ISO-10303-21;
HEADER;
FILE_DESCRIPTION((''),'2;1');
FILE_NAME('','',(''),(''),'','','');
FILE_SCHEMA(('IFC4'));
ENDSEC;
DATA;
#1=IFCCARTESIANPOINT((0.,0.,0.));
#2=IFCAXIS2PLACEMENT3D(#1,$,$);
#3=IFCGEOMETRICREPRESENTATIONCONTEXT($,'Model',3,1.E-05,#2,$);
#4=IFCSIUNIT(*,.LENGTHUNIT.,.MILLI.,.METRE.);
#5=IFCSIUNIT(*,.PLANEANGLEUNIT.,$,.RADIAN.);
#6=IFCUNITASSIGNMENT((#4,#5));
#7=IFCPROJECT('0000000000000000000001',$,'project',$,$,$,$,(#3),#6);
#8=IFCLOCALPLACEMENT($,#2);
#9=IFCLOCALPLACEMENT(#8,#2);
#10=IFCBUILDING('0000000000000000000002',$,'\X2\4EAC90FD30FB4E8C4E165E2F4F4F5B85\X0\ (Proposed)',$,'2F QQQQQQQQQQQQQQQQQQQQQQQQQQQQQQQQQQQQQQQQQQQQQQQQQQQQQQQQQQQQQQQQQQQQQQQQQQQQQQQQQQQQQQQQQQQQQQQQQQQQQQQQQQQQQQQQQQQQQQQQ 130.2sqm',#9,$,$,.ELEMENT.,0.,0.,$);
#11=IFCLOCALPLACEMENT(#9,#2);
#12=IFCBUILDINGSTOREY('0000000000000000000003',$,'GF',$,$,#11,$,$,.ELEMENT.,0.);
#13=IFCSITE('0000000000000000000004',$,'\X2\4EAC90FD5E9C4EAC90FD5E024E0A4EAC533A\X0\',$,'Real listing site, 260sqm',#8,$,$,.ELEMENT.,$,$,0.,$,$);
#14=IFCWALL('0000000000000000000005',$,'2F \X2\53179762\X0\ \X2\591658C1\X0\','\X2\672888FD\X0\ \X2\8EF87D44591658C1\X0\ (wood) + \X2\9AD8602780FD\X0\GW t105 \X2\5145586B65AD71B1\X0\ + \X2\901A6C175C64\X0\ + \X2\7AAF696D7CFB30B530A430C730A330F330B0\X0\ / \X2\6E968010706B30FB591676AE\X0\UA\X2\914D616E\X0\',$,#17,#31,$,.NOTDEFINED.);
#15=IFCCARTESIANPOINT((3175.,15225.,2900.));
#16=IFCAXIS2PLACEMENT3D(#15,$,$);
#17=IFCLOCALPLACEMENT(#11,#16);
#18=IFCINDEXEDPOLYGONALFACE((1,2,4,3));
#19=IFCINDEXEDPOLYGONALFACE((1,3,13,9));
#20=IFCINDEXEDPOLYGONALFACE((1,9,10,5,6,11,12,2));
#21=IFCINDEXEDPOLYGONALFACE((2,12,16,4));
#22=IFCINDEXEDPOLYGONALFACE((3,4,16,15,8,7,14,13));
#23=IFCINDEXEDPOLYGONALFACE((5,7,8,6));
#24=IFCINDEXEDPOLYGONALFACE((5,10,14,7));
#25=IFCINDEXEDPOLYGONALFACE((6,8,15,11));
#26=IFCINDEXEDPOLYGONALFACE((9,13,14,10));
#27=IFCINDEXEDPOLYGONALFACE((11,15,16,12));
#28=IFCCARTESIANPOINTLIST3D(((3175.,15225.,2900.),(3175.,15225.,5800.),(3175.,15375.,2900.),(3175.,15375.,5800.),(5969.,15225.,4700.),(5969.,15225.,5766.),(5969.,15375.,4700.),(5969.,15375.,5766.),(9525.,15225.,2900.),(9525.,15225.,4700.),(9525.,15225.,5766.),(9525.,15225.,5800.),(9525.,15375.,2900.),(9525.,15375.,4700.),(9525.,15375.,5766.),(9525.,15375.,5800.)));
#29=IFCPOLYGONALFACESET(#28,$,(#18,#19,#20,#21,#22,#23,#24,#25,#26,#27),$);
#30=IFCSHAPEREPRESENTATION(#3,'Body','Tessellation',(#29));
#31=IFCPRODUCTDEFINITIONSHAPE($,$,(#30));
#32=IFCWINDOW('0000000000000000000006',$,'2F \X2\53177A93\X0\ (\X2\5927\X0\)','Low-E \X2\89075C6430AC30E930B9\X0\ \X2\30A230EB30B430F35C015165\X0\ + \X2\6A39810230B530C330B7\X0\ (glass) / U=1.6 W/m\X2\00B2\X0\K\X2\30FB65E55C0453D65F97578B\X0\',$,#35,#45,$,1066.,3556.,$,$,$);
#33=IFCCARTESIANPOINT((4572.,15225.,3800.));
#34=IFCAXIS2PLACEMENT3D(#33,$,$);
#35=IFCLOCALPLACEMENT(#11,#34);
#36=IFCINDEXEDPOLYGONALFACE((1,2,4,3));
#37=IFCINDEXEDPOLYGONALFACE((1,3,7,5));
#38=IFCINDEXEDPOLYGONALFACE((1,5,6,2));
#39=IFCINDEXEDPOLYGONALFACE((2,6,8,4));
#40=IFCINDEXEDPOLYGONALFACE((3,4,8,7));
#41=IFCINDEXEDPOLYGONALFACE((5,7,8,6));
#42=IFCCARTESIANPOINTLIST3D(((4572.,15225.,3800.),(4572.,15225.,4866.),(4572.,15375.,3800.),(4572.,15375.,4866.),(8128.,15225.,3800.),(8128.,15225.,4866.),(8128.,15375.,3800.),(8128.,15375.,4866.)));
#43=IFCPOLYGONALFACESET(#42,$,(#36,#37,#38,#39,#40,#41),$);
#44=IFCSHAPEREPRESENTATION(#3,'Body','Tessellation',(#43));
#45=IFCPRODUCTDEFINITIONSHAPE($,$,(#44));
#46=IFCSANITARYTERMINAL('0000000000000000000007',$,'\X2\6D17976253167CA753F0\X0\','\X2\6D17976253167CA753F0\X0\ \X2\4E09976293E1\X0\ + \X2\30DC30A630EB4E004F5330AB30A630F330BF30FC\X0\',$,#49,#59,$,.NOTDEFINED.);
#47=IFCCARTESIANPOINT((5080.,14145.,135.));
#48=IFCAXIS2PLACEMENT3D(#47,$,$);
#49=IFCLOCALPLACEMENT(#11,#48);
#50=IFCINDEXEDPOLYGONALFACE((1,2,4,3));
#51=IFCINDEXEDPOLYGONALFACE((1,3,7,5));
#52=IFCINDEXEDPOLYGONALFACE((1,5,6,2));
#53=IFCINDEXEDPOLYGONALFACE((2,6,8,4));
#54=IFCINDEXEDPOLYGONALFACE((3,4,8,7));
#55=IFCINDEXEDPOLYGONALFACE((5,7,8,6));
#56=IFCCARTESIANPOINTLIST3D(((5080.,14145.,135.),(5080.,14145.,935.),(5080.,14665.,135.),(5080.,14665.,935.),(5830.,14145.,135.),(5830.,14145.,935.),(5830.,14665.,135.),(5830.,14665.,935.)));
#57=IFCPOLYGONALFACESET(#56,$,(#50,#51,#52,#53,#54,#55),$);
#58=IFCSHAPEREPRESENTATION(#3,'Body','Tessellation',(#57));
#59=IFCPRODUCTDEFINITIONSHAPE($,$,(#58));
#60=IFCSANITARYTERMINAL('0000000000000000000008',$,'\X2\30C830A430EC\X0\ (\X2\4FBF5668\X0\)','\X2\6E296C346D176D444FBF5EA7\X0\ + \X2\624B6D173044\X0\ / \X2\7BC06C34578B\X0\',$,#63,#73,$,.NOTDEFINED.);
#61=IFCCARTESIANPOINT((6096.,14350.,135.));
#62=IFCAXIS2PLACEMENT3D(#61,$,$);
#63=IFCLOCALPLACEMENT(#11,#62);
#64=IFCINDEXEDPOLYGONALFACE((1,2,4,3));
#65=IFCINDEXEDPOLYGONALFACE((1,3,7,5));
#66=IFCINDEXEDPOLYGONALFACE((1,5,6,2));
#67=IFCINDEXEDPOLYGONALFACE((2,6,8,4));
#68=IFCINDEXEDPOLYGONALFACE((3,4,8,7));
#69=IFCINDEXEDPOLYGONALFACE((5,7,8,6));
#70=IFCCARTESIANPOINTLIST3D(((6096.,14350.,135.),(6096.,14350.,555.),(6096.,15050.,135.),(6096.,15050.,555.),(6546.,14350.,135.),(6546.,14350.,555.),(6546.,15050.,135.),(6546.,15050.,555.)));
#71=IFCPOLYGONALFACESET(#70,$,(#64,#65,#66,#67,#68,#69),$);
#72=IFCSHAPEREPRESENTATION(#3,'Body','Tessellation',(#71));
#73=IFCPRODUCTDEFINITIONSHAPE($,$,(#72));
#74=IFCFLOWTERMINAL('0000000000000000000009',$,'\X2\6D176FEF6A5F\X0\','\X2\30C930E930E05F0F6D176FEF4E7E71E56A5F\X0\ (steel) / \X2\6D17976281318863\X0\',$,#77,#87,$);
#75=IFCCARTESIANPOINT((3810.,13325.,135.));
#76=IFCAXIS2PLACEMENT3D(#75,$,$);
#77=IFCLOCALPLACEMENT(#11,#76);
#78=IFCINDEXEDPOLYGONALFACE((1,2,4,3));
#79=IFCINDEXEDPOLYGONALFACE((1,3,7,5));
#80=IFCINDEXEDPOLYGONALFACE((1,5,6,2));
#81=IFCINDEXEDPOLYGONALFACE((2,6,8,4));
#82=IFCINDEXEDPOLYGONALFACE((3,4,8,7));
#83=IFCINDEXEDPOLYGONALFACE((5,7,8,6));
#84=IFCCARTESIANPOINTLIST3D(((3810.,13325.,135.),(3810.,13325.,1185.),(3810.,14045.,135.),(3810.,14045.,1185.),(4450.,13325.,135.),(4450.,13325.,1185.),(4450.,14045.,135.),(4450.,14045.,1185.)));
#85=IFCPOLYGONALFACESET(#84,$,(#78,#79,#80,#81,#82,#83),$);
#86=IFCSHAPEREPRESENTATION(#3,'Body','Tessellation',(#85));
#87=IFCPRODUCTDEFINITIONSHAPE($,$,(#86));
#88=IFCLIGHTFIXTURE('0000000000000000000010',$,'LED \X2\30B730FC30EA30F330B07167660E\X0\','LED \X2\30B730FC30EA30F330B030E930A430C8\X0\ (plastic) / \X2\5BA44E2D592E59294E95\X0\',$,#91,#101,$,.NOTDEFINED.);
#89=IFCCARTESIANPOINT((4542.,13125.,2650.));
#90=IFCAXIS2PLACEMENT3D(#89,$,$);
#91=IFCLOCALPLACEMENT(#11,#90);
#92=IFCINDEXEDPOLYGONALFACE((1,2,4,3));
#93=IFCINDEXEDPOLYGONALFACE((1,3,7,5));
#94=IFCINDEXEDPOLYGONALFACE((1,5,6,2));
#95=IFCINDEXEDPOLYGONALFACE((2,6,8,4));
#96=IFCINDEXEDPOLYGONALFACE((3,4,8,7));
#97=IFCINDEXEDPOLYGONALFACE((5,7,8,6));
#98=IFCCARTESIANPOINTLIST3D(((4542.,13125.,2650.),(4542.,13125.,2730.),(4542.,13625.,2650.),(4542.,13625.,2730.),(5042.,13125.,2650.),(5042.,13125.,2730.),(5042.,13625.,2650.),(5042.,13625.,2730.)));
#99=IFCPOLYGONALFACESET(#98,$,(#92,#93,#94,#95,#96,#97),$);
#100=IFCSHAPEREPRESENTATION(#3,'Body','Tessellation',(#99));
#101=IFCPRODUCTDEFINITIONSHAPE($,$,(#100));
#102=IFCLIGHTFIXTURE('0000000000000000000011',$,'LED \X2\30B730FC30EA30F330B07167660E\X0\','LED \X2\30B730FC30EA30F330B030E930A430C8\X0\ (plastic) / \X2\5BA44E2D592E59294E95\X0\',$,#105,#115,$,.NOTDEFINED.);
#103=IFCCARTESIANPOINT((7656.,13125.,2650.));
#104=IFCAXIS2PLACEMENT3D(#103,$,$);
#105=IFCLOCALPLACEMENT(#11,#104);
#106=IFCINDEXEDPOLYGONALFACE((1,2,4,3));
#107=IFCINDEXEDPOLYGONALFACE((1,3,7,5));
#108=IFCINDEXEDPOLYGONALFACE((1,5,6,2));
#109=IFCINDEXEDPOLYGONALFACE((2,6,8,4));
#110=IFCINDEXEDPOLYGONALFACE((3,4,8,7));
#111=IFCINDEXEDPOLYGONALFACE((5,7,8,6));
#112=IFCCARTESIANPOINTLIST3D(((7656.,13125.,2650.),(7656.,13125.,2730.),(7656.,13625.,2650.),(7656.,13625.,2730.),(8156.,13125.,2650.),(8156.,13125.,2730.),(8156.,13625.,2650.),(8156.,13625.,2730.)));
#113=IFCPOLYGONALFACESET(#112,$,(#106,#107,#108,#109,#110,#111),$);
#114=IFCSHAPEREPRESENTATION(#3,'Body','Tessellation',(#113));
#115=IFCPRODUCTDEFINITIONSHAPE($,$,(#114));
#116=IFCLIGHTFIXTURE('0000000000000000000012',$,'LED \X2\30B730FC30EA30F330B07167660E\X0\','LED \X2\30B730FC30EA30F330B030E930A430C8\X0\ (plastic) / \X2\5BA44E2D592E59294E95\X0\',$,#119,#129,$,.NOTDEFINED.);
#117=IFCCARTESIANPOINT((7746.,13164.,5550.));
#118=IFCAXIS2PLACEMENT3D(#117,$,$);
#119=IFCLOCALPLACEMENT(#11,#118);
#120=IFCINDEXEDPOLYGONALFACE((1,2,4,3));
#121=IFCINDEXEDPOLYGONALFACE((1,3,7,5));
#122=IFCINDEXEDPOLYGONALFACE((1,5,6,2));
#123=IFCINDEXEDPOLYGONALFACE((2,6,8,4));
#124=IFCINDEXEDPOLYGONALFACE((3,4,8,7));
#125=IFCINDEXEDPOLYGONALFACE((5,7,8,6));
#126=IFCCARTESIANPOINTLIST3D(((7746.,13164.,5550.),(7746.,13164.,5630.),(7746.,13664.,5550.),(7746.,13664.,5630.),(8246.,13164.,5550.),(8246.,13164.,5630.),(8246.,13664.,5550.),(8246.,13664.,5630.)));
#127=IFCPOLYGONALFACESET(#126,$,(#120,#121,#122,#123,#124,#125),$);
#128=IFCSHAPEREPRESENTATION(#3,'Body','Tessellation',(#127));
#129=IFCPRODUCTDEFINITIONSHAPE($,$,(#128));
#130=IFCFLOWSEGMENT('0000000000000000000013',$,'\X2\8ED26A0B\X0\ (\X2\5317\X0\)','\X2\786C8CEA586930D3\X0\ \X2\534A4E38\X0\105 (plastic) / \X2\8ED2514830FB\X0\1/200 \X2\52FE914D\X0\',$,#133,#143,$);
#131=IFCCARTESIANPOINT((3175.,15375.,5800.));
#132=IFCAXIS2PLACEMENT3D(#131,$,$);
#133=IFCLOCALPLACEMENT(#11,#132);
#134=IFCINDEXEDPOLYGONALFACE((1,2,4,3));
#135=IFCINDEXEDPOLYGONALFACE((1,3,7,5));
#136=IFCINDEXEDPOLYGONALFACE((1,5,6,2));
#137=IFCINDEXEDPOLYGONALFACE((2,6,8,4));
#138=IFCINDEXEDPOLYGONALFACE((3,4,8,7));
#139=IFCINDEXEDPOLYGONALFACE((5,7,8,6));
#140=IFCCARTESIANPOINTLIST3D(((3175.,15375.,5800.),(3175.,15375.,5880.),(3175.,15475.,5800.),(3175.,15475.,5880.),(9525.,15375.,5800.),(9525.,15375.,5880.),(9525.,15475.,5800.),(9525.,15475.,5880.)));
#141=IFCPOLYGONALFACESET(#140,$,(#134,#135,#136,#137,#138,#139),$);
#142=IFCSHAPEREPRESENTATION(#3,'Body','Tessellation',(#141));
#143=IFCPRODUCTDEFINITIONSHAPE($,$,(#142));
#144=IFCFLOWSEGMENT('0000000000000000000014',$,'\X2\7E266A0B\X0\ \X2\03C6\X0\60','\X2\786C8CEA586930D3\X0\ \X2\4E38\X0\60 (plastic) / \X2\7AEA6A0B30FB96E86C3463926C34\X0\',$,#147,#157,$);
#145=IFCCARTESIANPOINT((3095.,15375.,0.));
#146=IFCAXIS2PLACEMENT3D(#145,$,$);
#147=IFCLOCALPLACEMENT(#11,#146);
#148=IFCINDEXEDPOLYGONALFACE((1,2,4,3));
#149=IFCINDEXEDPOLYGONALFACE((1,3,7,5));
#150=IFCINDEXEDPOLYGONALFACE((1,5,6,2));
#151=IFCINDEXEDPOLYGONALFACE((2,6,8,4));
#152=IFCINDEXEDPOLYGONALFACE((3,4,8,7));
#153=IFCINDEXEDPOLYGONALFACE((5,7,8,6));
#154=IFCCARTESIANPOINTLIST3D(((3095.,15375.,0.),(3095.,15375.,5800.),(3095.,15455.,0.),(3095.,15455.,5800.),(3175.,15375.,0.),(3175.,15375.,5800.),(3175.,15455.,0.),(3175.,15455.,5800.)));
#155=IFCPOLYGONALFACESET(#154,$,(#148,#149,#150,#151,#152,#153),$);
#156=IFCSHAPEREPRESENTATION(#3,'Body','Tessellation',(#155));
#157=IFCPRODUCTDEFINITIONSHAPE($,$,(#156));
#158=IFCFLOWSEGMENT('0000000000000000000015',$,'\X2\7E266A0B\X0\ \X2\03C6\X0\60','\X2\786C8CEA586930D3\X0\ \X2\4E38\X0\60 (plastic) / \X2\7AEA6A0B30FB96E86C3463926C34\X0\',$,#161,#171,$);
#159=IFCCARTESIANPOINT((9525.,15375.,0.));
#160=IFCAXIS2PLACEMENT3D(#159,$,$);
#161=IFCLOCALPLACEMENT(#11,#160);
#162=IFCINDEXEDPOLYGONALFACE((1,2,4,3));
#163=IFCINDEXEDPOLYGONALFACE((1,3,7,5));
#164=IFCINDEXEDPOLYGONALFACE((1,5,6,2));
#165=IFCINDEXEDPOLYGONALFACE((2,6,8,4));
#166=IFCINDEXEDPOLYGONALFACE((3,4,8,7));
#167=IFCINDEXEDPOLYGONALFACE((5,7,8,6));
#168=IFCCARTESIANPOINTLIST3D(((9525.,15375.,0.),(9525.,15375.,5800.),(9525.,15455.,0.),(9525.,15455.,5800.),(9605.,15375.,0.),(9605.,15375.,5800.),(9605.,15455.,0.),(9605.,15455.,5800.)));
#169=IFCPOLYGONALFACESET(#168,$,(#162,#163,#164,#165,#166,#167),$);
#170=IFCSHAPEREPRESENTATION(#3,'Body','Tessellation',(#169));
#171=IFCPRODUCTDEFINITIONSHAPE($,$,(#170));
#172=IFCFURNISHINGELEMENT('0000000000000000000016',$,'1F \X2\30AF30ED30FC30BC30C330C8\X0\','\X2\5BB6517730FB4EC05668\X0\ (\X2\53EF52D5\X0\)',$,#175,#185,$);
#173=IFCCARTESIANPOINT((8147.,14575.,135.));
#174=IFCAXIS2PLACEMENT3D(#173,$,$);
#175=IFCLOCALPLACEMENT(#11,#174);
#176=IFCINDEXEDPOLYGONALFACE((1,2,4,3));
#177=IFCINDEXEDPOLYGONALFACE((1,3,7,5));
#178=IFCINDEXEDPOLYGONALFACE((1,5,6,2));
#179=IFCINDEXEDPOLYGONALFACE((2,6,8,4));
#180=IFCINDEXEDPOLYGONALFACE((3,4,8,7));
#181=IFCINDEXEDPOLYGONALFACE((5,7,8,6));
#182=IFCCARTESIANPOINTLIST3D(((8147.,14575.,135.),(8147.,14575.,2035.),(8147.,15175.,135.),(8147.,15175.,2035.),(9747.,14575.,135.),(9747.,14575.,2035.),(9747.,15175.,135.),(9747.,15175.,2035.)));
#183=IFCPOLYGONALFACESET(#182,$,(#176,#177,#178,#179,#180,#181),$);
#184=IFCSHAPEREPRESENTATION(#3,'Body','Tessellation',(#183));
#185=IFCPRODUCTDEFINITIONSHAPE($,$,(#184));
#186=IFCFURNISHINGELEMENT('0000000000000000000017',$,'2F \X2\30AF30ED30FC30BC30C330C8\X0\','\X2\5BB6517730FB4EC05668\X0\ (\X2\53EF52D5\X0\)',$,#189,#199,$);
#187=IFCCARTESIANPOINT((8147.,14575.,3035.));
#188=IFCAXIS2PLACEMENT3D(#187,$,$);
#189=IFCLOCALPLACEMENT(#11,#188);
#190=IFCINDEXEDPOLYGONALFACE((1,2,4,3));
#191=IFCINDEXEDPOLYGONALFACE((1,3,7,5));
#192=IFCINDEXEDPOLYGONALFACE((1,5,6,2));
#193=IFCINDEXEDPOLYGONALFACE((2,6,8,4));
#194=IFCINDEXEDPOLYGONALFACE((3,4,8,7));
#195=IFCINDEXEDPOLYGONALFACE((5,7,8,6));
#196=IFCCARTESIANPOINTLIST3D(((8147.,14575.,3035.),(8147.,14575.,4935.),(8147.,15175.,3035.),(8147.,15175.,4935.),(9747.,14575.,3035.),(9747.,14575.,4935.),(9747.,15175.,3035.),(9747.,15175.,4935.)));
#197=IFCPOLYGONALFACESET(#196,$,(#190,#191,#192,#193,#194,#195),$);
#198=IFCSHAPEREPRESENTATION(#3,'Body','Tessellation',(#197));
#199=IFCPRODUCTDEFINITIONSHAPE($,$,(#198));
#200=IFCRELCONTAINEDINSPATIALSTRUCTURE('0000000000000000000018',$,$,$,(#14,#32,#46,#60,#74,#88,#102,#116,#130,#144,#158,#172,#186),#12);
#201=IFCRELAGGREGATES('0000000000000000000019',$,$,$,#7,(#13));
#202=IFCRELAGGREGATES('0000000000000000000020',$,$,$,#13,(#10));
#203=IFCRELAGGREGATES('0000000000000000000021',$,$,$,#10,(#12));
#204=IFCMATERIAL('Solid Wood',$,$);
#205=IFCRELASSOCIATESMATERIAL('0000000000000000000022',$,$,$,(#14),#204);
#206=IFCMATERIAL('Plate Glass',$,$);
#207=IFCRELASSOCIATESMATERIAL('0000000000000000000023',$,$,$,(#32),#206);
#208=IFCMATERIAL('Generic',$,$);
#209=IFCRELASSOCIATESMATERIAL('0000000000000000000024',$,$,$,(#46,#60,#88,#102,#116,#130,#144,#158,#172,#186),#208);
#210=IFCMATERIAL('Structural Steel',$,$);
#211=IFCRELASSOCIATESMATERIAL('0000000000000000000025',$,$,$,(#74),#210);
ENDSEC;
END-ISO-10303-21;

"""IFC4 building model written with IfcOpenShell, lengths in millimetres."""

from ifc_helpers import new_model, si_unit, frame, frame_2d, origin, place, context, project, spatial, rectangle, extrude, material, element, fill, save


model = new_model("IFC4")

# Units and contexts
model_context = context("Model", 3, precision=1e-05, world=origin())
ifc_project = project(units=[si_unit("LENGTHUNIT", "METRE", prefix="MILLI"), si_unit("PLANEANGLEUNIT", "RADIAN")], contexts=[model_context])

# Site, building, storey
site_placement = place(None, origin())
site = spatial("IfcSite", under=ifc_project, at=site_placement, Name="京都府京都市上京区", ObjectType="Real listing site, 260sqm", CompositionType="ELEMENT", RefElevation=0.0)
building_placement = place(site_placement, origin())
building = spatial("IfcBuilding", under=site, at=building_placement, Name="京都・二世帯住宅 (Proposed)", ObjectType="2F QQQQQQQQQQQQQQQQQQQQQQQQQQQQQQQQQQQQQQQQQQQQQQQQQQQQQQQQQQQQQQQQQQQQQQQQQQQQQQQQQQQQQQQQQQQQQQQQQQQQQQQQQQQQQQQQQQQQQQQQ 130.2sqm", CompositionType="ELEMENT", ElevationOfRefHeight=0.0, ElevationOfTerrain=0.0)
storey_placement = place(building_placement, origin())
storey = spatial("IfcBuildingStorey", under=building, at=storey_placement, Name="GF", CompositionType="ELEMENT", Elevation=0.0)

# Shared definitions
ifc_material_1 = material(Name="Solid Wood")

# Shared definitions
ifc_material_2 = material(Name="Plate Glass")

# Wall, opening, window
wall_1_placement = place(storey_placement, frame((3175.0, 15225.0, 2900.0)))
wall_1 = element("IfcWall", 1, at=wall_1_placement, inside=storey, material=ifc_material_1, Name="2F 北面 外壁", Description="木製 軸組外壁 (wood) + 高性能GW t105 充填断熱 + 通気層 + 窯業系サイディング / 準耐火・外皮UA配慮", PredefinedType="NOTDEFINED", context=model_context, shape_type="SweptSolid", body=[
    extrude(rectangle(XDim=6350.0, YDim=150.0, at=frame_2d((3175.0, 75.0))), frame((3175.0, 15225.0, 2900.0)), (0.0, 0.0, 1.0), 2900.0),
])
opening_1_placement = place(storey_placement, frame((4572.0, 15225.0, 3800.0)))
opening_1 = element("IfcOpeningElement", 2, at=opening_1_placement, cuts=wall_1, PredefinedType="NOTDEFINED", context=model_context, shape_type="SweptSolid", body=[
    extrude(rectangle(XDim=3556.0, YDim=150.0, at=frame_2d((1778.0, 75.0))), frame((4572.0, 15225.0, 3800.0)), (0.0, 0.0, 1.0), 1066.0),
])
window_1_placement = place(storey_placement, frame((4572.0, 15225.0, 3800.0)))
window_1 = element("IfcWindow", 3, at=window_1_placement, inside=storey, material=ifc_material_2, Name="2F 北窓 (大)", Description="Low-E 複層ガラス アルゴン封入 + 樹脂サッシ (glass) / U=1.6 W/m²K・日射取得型", OverallHeight=1066.0, OverallWidth=3556.0, context=model_context, shape_type="SweptSolid", body=[
    extrude(rectangle(XDim=3556.0, YDim=150.0, at=frame_2d((1778.0, 75.0))), frame((4572.0, 15225.0, 3800.0)), (0.0, 0.0, 1.0), 1066.0),
])
fill(opening_1, window_1)

# Sanitary terminals
ifc_material_3 = material(Name="Generic")
sanitary_terminal_1_placement = place(storey_placement, frame((5080.0, 14145.0, 135.0)))
element("IfcSanitaryTerminal", 4, at=sanitary_terminal_1_placement, inside=storey, material=ifc_material_3, Name="洗面化粧台", Description="洗面化粧台 三面鏡 + ボウル一体カウンター", PredefinedType="NOTDEFINED", context=model_context, shape_type="SweptSolid", body=[
    extrude(rectangle(XDim=750.0, YDim=520.0, at=frame_2d((375.0, 260.0))), frame((5080.0, 14145.0, 135.0)), (0.0, 0.0, 1.0), 800.0),
])
sanitary_terminal_2_placement = place(storey_placement, frame((6096.0, 14350.0, 135.0)))
element("IfcSanitaryTerminal", 5, at=sanitary_terminal_2_placement, inside=storey, material=ifc_material_3, Name="トイレ (便器)", Description="温水洗浄便座 + 手洗い / 節水型", PredefinedType="NOTDEFINED", context=model_context, shape_type="SweptSolid", body=[
    extrude(rectangle(XDim=450.0, YDim=700.0, at=frame_2d((225.0, 350.0))), frame((6096.0, 14350.0, 135.0)), (0.0, 0.0, 1.0), 420.0),
])

# Flow terminal
ifc_material_4 = material(Name="Structural Steel")
flow_terminal_placement = place(storey_placement, frame((3810.0, 13325.0, 135.0)))
element("IfcFlowTerminal", 6, at=flow_terminal_placement, inside=storey, material=ifc_material_4, Name="洗濯機", Description="ドラム式洗濯乾燥機 (steel) / 洗面脱衣", context=model_context, shape_type="SweptSolid", body=[
    extrude(rectangle(XDim=640.0, YDim=720.0, at=frame_2d((320.0, 360.0))), frame((3810.0, 13325.0, 135.0)), (0.0, 0.0, 1.0), 1050.0),
])

# Light fixtures
light_fixture_1_placement = place(storey_placement, frame((4542.0, 13125.0, 2650.0)))
element("IfcLightFixture", 7, at=light_fixture_1_placement, inside=storey, material=ifc_material_3, Name="LED シーリング照明", Description="LED シーリングライト (plastic) / 室中央天井", PredefinedType="NOTDEFINED", context=model_context, shape_type="SweptSolid", body=[
    extrude(rectangle(XDim=500.0, YDim=500.0, at=frame_2d((250.0, 250.0))), frame((4542.0, 13125.0, 2650.0)), (0.0, 0.0, 1.0), 80.0),
])
light_fixture_2_placement = place(storey_placement, frame((7656.0, 13125.0, 2650.0)))
element("IfcLightFixture", 8, at=light_fixture_2_placement, inside=storey, material=ifc_material_3, Name="LED シーリング照明", Description="LED シーリングライト (plastic) / 室中央天井", PredefinedType="NOTDEFINED", context=model_context, shape_type="SweptSolid", body=[
    extrude(rectangle(XDim=500.0, YDim=500.0, at=frame_2d((250.0, 250.0))), frame((7656.0, 13125.0, 2650.0)), (0.0, 0.0, 1.0), 80.0),
])
light_fixture_3_placement = place(storey_placement, frame((7746.0, 13164.0, 5550.0)))
element("IfcLightFixture", 9, at=light_fixture_3_placement, inside=storey, material=ifc_material_3, Name="LED シーリング照明", Description="LED シーリングライト (plastic) / 室中央天井", PredefinedType="NOTDEFINED", context=model_context, shape_type="SweptSolid", body=[
    extrude(rectangle(XDim=500.0, YDim=500.0, at=frame_2d((250.0, 250.0))), frame((7746.0, 13164.0, 5550.0)), (0.0, 0.0, 1.0), 80.0),
])

# Flow segments
flow_segment_1_placement = place(storey_placement, frame((3175.0, 15375.0, 5800.0)))
element("IfcFlowSegment", 10, at=flow_segment_1_placement, inside=storey, material=ifc_material_3, Name="軒樋 (北)", Description="硬質塩ビ 半丸105 (plastic) / 軒先・1/200 勾配", context=model_context, shape_type="SweptSolid", body=[
    extrude(rectangle(XDim=6350.0, YDim=100.0, at=frame_2d((3175.0, 50.0))), frame((3175.0, 15375.0, 5800.0)), (0.0, 0.0, 1.0), 80.0),
])
flow_segment_2_placement = place(storey_placement, frame((3095.0, 15375.0, 0.0)))
element("IfcFlowSegment", 11, at=flow_segment_2_placement, inside=storey, material=ifc_material_3, Name="縦樋 φ60", Description="硬質塩ビ 丸60 (plastic) / 竪樋・雨水排水", context=model_context, shape_type="SweptSolid", body=[
    extrude(rectangle(XDim=80.0, YDim=80.0, at=frame_2d((40.0, 40.0))), frame((3095.0, 15375.0, 0.0)), (0.0, 0.0, 1.0), 5800.0),
])
flow_segment_3_placement = place(storey_placement, frame((9525.0, 15375.0, 0.0)))
element("IfcFlowSegment", 12, at=flow_segment_3_placement, inside=storey, material=ifc_material_3, Name="縦樋 φ60", Description="硬質塩ビ 丸60 (plastic) / 竪樋・雨水排水", context=model_context, shape_type="SweptSolid", body=[
    extrude(rectangle(XDim=80.0, YDim=80.0, at=frame_2d((40.0, 40.0))), frame((9525.0, 15375.0, 0.0)), (0.0, 0.0, 1.0), 5800.0),
])

# Furnishing elements
furnishing_1_placement = place(storey_placement, frame((8147.0, 14575.0, 135.0)))
element("IfcFurnishingElement", 13, at=furnishing_1_placement, inside=storey, material=ifc_material_3, Name="1F クローゼット", Description="家具・什器 (可動)", context=model_context, shape_type="SweptSolid", body=[
    extrude(rectangle(XDim=1600.0, YDim=600.0, at=frame_2d((800.0, 300.0))), frame((8147.0, 14575.0, 135.0)), (0.0, 0.0, 1.0), 1900.0),
])
furnishing_2_placement = place(storey_placement, frame((8147.0, 14575.0, 3035.0)))
element("IfcFurnishingElement", 14, at=furnishing_2_placement, inside=storey, material=ifc_material_3, Name="2F クローゼット", Description="家具・什器 (可動)", context=model_context, shape_type="SweptSolid", body=[
    extrude(rectangle(XDim=1600.0, YDim=600.0, at=frame_2d((800.0, 300.0))), frame((8147.0, 14575.0, 3035.0)), (0.0, 0.0, 1.0), 1900.0),
])

save(model, "model.ifc")
